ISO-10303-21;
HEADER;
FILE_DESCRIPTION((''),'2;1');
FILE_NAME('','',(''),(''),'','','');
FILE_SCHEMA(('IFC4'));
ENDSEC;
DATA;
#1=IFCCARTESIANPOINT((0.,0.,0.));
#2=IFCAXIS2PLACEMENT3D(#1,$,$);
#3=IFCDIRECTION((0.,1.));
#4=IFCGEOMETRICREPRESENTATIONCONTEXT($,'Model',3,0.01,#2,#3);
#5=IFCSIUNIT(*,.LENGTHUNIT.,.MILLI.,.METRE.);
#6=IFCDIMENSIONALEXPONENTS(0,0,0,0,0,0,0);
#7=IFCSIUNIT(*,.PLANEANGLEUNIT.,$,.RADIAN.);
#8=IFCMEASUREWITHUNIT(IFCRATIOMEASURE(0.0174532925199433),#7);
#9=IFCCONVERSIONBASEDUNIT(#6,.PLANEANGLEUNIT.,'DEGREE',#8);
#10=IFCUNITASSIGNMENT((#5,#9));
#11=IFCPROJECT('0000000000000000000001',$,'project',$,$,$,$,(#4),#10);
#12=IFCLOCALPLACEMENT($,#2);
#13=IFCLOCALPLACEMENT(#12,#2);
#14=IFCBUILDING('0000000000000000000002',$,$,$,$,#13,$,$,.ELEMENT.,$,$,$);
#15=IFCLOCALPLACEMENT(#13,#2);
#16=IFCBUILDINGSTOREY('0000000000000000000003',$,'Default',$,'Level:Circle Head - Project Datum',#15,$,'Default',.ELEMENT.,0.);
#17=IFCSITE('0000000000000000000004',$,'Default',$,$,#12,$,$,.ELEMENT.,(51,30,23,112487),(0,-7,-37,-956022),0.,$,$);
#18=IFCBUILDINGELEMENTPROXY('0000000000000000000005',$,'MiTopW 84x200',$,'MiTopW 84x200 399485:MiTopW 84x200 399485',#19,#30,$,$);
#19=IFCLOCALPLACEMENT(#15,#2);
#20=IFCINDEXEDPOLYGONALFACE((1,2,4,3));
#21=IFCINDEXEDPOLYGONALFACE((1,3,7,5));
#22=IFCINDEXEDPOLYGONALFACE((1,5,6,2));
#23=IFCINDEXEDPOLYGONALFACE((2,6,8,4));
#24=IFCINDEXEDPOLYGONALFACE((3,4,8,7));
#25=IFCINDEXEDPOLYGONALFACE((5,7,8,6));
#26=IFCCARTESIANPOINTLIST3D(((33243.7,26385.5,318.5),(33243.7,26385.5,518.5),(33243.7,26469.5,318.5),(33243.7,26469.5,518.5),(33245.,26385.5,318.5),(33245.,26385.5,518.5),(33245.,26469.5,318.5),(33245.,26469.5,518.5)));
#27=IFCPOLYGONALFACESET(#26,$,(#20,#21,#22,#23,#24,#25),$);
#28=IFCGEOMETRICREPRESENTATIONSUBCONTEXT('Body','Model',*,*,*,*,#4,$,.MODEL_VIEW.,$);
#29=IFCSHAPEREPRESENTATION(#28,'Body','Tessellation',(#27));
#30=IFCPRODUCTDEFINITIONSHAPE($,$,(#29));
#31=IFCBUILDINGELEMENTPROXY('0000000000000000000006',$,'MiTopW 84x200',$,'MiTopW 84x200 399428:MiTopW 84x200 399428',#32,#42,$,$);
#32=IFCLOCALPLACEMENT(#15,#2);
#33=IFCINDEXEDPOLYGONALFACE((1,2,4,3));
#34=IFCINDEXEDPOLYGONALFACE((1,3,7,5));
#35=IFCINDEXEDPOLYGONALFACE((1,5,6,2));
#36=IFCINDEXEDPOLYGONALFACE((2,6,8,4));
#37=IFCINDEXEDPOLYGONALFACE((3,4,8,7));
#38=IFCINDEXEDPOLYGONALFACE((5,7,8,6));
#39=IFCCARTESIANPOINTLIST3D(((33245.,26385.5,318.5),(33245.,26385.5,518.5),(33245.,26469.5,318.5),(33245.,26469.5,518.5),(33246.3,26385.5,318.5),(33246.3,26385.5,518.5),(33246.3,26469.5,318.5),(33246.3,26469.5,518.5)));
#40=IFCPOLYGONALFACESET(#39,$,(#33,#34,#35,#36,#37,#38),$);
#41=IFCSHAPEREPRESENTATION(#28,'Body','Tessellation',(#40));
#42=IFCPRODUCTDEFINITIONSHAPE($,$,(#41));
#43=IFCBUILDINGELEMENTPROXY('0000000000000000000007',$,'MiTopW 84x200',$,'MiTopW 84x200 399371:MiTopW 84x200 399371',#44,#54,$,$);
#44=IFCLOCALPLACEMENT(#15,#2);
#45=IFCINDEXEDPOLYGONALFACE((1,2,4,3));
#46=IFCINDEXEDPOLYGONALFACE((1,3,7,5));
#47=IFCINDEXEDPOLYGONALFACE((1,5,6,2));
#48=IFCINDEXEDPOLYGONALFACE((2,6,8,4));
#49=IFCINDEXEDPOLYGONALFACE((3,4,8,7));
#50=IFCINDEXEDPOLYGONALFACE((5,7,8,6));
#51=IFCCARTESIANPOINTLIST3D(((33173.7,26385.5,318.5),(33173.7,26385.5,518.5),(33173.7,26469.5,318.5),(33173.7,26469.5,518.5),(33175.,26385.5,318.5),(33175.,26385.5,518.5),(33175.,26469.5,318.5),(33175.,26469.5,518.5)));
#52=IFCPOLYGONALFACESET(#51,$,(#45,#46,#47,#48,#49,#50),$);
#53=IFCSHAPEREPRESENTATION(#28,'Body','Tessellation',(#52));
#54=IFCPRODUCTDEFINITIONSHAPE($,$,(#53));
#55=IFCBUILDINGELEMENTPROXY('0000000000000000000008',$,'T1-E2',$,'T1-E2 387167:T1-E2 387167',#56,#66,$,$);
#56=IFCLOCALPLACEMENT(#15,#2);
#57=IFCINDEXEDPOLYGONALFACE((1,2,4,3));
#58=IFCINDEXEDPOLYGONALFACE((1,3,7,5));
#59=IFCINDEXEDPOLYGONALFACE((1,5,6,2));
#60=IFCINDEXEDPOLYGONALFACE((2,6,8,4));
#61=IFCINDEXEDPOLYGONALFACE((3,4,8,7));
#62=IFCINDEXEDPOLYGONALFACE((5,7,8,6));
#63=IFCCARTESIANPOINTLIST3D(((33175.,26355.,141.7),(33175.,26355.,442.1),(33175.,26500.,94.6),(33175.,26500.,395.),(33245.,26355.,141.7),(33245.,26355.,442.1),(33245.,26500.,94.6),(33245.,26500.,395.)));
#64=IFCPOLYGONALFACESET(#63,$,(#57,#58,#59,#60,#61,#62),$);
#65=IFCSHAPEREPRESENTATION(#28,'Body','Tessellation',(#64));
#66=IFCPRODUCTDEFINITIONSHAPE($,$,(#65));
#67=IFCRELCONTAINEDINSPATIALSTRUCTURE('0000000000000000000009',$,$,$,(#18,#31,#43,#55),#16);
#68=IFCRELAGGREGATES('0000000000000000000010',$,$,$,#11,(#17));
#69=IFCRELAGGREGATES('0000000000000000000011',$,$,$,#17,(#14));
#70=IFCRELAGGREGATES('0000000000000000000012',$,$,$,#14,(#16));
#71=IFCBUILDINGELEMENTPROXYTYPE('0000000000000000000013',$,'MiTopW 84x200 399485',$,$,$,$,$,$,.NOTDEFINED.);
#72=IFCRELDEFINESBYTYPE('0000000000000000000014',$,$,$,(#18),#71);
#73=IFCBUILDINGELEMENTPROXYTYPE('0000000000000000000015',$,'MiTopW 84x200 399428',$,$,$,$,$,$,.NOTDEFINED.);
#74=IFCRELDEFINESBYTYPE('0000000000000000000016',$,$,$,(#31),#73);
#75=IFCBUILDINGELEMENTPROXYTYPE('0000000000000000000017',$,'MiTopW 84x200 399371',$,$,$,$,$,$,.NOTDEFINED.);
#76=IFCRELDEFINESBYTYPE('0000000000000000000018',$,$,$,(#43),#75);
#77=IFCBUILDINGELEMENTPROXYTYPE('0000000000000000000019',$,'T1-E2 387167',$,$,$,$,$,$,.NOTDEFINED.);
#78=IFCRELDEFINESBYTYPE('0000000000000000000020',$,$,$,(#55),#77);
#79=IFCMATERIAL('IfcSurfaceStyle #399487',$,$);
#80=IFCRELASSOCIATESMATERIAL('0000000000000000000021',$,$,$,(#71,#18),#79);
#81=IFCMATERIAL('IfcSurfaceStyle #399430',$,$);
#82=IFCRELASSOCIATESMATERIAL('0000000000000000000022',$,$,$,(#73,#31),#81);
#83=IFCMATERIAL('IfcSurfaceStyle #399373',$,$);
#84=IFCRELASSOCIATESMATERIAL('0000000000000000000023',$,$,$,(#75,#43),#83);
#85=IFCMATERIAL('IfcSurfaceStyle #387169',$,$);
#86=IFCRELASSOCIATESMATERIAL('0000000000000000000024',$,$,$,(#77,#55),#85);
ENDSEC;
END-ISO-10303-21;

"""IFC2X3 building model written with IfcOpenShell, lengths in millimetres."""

from ifc_helpers import new_model, entity, si_unit, converted_unit, direction, frame, frame_2d, origin, place, context, subcontext, project, spatial, polyline, rectangle, outline, extrude, source, transform, mapped, material, type_object, type_shapes, element, save


model = new_model("IFC2X3")

# Units and contexts
model_context = context("Model", 3, precision=0.01, world=origin(), true_north=direction((0.0, 1.0)))
body_context = subcontext(model_context, "Body", "Model", "MODEL_VIEW")
ifc_project = project(units=[si_unit("LENGTHUNIT", "METRE", prefix="MILLI"), converted_unit("PLANEANGLEUNIT", "DEGREE", entity("IfcRatioMeasure", 0.0174532925199433), si_unit("PLANEANGLEUNIT", "RADIAN"), dimensions=[0, 0, 0, 0, 0, 0, 0])], contexts=[model_context])

# Site, building, storey
site_placement = place(None, origin())
site = spatial("IfcSite", under=ifc_project, at=site_placement, Name="Default", CompositionType="ELEMENT", RefLatitude=(51, 30, 23, 112487), RefLongitude=(0, -7, -37, -956022), RefElevation=0.0)
building_placement = place(site_placement, origin())
building = spatial("IfcBuilding", under=site, at=building_placement, CompositionType="ELEMENT")
storey_placement = place(building_placement, origin())
storey = spatial("IfcBuildingStorey", under=building, at=storey_placement, Name="Default", ObjectType="Level:Circle Head - Project Datum", LongName="Default", CompositionType="ELEMENT", Elevation=0.0)

# Building element proxies
ifc_material_1 = material(Name="IfcSurfaceStyle #399487")
building_element_proxy_type_1 = type_object("IfcBuildingElementProxyType", Name="MiTopW 84x200 399485", PredefinedType="NOTDEFINED", material=ifc_material_1)
shared_shape_1 = source(origin(), body_context, "Body", "SweptSolid", [
    extrude(rectangle(XDim=200.0, YDim=84.0, at=frame_2d((0.0, 0.0), x_axis=(1.0, 0.0))), frame((100.0, 42.0, 0.0), z_axis=(0.0, 0.0, 1.0), x_axis=(-1.0, 0.0, 0.0)), (0.0, 0.0, 1.0), 1.3),
])
type_shapes(building_element_proxy_type_1, [shared_shape_1])
proxy_1_placement = place(building_placement, frame((33245.0, 26469.5, 518.5), z_axis=(-1.0, 0.0, 0.0), x_axis=(0.0, 0.0, -1.0)))
element("IfcBuildingElementProxy", 1, at=proxy_1_placement, inside=storey, type_object=building_element_proxy_type_1, material=ifc_material_1, Name="MiTopW 84x200", ObjectType="MiTopW 84x200 399485:MiTopW 84x200 399485", context=body_context, shape_type="MappedRepresentation", body=[
    mapped(shared_shape_1, transform((0.0, 0.0, 0.0), scale=1.0)),
])
ifc_material_2 = material(Name="IfcSurfaceStyle #399430")
building_element_proxy_type_2 = type_object("IfcBuildingElementProxyType", Name="MiTopW 84x200 399428", PredefinedType="NOTDEFINED", material=ifc_material_2)
shared_shape_2 = source(origin(), body_context, "Body", "SweptSolid", [
    extrude(rectangle(XDim=200.0, YDim=84.0, at=frame_2d((0.0, 0.0), x_axis=(1.0, 0.0))), frame((100.0, 42.0, 0.0), z_axis=(0.0, 0.0, 1.0), x_axis=(-1.0, 0.0, 0.0)), (0.0, 0.0, 1.0), 1.3),
])
type_shapes(building_element_proxy_type_2, [shared_shape_2])
proxy_2_placement = place(building_placement, frame((33246.3, 26469.5, 518.5), z_axis=(-1.0, 0.0, 0.0), x_axis=(0.0, 0.0, -1.0)))
element("IfcBuildingElementProxy", 2, at=proxy_2_placement, inside=storey, type_object=building_element_proxy_type_2, material=ifc_material_2, Name="MiTopW 84x200", ObjectType="MiTopW 84x200 399428:MiTopW 84x200 399428", context=body_context, shape_type="MappedRepresentation", body=[
    mapped(shared_shape_2, transform((0.0, 0.0, 0.0), scale=1.0)),
])
ifc_material_3 = material(Name="IfcSurfaceStyle #399373")
building_element_proxy_type_3 = type_object("IfcBuildingElementProxyType", Name="MiTopW 84x200 399371", PredefinedType="NOTDEFINED", material=ifc_material_3)
shared_shape_3 = source(origin(), body_context, "Body", "SweptSolid", [
    extrude(rectangle(XDim=200.0, YDim=84.0, at=frame_2d((0.0, 0.0), x_axis=(1.0, 0.0))), frame((100.0, 42.0, 0.0), z_axis=(0.0, 0.0, 1.0), x_axis=(-1.0, 0.0, 0.0)), (0.0, 0.0, 1.0), 1.3),
])
type_shapes(building_element_proxy_type_3, [shared_shape_3])
proxy_3_placement = place(building_placement, frame((33175.0, 26469.5, 518.5), z_axis=(-1.0, 0.0, 0.0), x_axis=(0.0, 0.0, -1.0)))
element("IfcBuildingElementProxy", 3, at=proxy_3_placement, inside=storey, type_object=building_element_proxy_type_3, material=ifc_material_3, Name="MiTopW 84x200", ObjectType="MiTopW 84x200 399371:MiTopW 84x200 399371", context=body_context, shape_type="MappedRepresentation", body=[
    mapped(shared_shape_3, transform((0.0, 0.0, 0.0), scale=1.0)),
])
ifc_material_4 = material(Name="IfcSurfaceStyle #387169")
building_element_proxy_type_4 = type_object("IfcBuildingElementProxyType", Name="T1-E2 387167", PredefinedType="NOTDEFINED", material=ifc_material_4)
shared_shape_4 = source(origin(), body_context, "Body", "SweptSolid", [
    extrude(outline(polyline([(-126.6, -72.5), (173.8, -72.5), (126.6, 72.5), (-173.8, 72.5), (-126.6, -72.5)])), frame((173.8, 72.5, 0.0), z_axis=(0.0, 0.0, 1.0), x_axis=(-1.0, 0.0, 0.0)), (0.0, 0.0, 1.0), 70.0),
])
type_shapes(building_element_proxy_type_4, [shared_shape_4])
proxy_4_placement = place(building_placement, frame((33245.0, 26500.0, 442.1), z_axis=(-1.0, 0.0, 0.0), x_axis=(0.0, 0.0, -1.0)))
element("IfcBuildingElementProxy", 4, at=proxy_4_placement, inside=storey, type_object=building_element_proxy_type_4, material=ifc_material_4, Name="T1-E2", ObjectType="T1-E2 387167:T1-E2 387167", context=body_context, shape_type="MappedRepresentation", body=[
    mapped(shared_shape_4, transform((0.0, 0.0, 0.0), scale=1.0)),
])

save(model, "model.ifc")
